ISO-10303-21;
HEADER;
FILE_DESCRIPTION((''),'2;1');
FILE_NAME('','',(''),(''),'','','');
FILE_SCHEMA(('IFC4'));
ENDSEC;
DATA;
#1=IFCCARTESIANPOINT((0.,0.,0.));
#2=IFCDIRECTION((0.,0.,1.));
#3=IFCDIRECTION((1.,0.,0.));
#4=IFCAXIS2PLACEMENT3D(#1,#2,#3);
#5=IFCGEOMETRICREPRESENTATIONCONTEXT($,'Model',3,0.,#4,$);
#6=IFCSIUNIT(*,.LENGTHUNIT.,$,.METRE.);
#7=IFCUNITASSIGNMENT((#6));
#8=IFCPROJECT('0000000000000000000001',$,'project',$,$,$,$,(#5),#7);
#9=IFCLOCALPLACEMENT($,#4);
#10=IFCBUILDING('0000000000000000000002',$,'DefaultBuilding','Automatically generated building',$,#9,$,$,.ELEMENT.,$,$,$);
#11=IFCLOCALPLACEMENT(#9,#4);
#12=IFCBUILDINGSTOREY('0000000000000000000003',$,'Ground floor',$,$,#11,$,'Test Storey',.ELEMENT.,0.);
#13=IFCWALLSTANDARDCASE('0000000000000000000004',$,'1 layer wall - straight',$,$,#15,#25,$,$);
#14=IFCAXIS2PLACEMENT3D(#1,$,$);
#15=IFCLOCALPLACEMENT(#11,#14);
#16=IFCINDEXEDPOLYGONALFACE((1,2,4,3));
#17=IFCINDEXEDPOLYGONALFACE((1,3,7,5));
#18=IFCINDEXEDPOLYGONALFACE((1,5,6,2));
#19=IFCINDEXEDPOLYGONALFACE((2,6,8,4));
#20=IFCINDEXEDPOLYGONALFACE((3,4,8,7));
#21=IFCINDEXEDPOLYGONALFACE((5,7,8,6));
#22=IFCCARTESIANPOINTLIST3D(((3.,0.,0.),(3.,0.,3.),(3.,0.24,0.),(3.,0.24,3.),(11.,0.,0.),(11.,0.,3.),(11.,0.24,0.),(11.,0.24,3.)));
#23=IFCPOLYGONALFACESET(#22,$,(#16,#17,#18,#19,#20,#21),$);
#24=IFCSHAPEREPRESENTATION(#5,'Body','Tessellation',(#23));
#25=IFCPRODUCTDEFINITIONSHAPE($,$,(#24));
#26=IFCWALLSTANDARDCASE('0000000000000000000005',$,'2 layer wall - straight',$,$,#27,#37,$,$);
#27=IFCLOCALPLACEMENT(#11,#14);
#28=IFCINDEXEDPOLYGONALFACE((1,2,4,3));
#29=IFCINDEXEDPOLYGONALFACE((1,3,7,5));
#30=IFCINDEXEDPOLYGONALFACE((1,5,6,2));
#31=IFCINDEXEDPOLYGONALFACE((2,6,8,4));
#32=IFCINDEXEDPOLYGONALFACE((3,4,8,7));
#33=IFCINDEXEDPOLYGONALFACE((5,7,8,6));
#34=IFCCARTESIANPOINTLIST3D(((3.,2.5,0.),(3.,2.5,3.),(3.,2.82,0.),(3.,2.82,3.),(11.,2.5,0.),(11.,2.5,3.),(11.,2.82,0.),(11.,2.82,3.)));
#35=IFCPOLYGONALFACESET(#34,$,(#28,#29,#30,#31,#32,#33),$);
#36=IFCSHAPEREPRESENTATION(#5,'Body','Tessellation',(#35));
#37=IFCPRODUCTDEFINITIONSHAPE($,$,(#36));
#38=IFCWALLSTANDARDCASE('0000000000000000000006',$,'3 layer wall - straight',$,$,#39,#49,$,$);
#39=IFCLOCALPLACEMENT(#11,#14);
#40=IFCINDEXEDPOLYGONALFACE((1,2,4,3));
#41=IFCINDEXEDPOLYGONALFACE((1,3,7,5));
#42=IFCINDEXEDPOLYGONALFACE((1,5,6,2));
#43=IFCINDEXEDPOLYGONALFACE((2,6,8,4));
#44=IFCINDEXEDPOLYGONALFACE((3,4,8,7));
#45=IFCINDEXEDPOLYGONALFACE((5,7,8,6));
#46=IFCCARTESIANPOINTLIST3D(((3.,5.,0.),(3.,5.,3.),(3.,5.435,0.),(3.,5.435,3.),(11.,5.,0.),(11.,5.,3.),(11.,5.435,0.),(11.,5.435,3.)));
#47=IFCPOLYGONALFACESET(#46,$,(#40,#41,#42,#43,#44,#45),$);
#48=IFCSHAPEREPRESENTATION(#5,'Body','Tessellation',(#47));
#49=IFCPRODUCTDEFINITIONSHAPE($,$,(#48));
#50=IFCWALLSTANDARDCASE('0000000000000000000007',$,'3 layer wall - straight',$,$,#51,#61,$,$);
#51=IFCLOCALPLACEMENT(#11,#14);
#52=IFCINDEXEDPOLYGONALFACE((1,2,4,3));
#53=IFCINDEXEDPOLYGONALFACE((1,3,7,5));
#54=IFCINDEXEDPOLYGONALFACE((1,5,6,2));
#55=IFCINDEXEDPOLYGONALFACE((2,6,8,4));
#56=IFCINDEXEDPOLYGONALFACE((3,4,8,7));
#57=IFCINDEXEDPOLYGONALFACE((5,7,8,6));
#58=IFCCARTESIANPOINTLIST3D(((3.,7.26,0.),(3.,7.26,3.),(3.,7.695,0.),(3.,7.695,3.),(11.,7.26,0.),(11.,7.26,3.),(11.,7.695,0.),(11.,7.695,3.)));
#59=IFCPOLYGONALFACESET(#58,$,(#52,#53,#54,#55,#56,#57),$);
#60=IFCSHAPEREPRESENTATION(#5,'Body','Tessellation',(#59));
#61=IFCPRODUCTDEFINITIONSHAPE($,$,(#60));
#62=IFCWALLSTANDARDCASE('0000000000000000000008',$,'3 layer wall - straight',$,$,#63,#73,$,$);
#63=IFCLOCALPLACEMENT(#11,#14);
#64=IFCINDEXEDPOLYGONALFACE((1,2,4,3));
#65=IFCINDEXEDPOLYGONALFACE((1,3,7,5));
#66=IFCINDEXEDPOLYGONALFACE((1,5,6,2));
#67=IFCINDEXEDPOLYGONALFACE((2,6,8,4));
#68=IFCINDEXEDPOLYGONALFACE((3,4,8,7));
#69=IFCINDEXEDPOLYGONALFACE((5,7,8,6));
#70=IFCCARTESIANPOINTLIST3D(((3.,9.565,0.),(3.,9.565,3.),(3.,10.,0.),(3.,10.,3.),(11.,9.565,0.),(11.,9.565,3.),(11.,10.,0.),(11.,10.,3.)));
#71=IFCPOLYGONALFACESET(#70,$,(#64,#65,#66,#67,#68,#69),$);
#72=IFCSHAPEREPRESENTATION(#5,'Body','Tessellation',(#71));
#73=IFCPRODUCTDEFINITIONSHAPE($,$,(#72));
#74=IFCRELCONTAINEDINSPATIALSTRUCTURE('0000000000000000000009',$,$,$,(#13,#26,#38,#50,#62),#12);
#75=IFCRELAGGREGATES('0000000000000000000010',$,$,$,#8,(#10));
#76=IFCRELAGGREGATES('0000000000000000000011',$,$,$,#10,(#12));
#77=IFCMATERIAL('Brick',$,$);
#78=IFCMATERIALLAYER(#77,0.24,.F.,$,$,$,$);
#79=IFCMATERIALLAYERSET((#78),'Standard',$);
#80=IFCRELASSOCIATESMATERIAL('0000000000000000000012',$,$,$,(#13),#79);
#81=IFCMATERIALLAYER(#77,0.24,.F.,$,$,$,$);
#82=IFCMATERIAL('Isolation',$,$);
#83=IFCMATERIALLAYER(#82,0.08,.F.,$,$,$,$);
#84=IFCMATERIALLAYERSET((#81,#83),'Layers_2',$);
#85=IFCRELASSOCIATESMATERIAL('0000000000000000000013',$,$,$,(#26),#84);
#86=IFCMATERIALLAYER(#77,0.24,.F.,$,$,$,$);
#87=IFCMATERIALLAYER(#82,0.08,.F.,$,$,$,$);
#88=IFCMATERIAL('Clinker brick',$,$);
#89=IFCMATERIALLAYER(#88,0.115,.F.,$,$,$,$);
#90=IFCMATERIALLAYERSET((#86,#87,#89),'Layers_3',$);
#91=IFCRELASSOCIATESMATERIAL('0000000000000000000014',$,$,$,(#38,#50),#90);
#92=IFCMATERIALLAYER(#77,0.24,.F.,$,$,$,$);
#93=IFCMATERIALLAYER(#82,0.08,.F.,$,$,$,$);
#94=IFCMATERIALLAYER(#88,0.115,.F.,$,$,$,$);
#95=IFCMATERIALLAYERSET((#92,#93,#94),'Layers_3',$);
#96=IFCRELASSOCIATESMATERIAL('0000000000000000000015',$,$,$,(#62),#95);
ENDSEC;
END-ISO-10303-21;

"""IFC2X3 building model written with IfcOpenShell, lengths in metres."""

from ifc_helpers import new_model, si_unit, frame, origin_with_axes, place, context, project, spatial, polyline, outline, extrude, material, layer, layer_set, layer_usage, element, save


model = new_model("IFC2X3")

# Units and contexts
model_context = context("Model", 3, precision=0.0, world=origin_with_axes())
ifc_project = project(units=[si_unit("LENGTHUNIT", "METRE")], contexts=[model_context])

# Building, storey
building_placement = place(None, origin_with_axes())
building = spatial("IfcBuilding", under=ifc_project, at=building_placement, Name="DefaultBuilding", Description="Automatically generated building", CompositionType="ELEMENT")
storey_placement = place(building_placement, origin_with_axes())
storey = spatial("IfcBuildingStorey", under=building, at=storey_placement, Name="Ground floor", LongName="Test Storey", CompositionType="ELEMENT", Elevation=0.0)

# Walls
ifc_material_1 = material(Name="Brick")
ifc_layer_1 = layer(ifc_material_1, 0.24, ventilated=False)
ifc_layer_set_1 = layer_set([ifc_layer_1], Name="Standard")
ifc_layer_usage_1 = layer_usage(ifc_layer_set_1, "AXIS2", "POSITIVE", 0.0)
wall_1_placement = place(storey_placement, frame((3.0, 0.0, 0.0), z_axis=(0.0, 0.0, 1.0), x_axis=(1.0, 0.0, 0.0)))
element("IfcWallStandardCase", 1, at=wall_1_placement, inside=storey, material=ifc_layer_usage_1, Name="1 layer wall - straight", context=model_context, shape_type="SweptSolid", body=[
    extrude(outline(polyline([(0.0, 0.24), (0.0, 0.0), (8.0, 0.0), (8.0, 0.24), (0.0, 0.24)])), origin_with_axes(), (0.0, 0.0, 1.0), 3.0),
])
ifc_layer_2 = layer(ifc_material_1, 0.24, ventilated=False)
ifc_material_2 = material(Name="Isolation")
ifc_layer_3 = layer(ifc_material_2, 0.08, ventilated=False)
ifc_layer_set_2 = layer_set([ifc_layer_2, ifc_layer_3], Name="Layers_2")
ifc_layer_usage_2 = layer_usage(ifc_layer_set_2, "AXIS2", "POSITIVE", 0.0)
wall_2_placement = place(storey_placement, frame((3.0, 2.5, 0.0), z_axis=(0.0, 0.0, 1.0), x_axis=(1.0, 0.0, 0.0)))
element("IfcWallStandardCase", 2, at=wall_2_placement, inside=storey, material=ifc_layer_usage_2, Name="2 layer wall - straight", context=model_context, shape_type="SweptSolid", body=[
    extrude(outline(polyline([(0.0, 0.0), (8.0, 0.0), (8.0, 0.32), (0.0, 0.32), (0.0, 0.0)])), origin_with_axes(), (0.0, 0.0, 1.0), 3.0),
])
ifc_layer_4 = layer(ifc_material_1, 0.24, ventilated=False)
ifc_layer_5 = layer(ifc_material_2, 0.08, ventilated=False)
ifc_material_3 = material(Name="Clinker brick")
ifc_layer_6 = layer(ifc_material_3, 0.115, ventilated=False)
ifc_layer_set_3 = layer_set([ifc_layer_4, ifc_layer_5, ifc_layer_6], Name="Layers_3")
ifc_layer_usage_3 = layer_usage(ifc_layer_set_3, "AXIS2", "POSITIVE", 0.0)
wall_3_placement = place(storey_placement, frame((3.0, 5.0, 0.0), z_axis=(0.0, 0.0, 1.0), x_axis=(1.0, 0.0, 0.0)))
element("IfcWallStandardCase", 3, at=wall_3_placement, inside=storey, material=ifc_layer_usage_3, Name="3 layer wall - straight", context=model_context, shape_type="SweptSolid", body=[
    extrude(outline(polyline([(0.0, 0.0), (8.0, 0.0), (8.0, 0.435), (0.0, 0.435), (0.0, 0.0)])), origin_with_axes(), (0.0, 0.0, 1.0), 3.0),
])
ifc_layer_usage_4 = layer_usage(ifc_layer_set_3, "AXIS2", "POSITIVE", -0.2175)
wall_4_placement = place(storey_placement, frame((3.0, 7.4775, 0.0), z_axis=(0.0, 0.0, 1.0), x_axis=(1.0, 0.0, 0.0)))
element("IfcWallStandardCase", 4, at=wall_4_placement, inside=storey, material=ifc_layer_usage_4, Name="3 layer wall - straight", context=model_context, shape_type="SweptSolid", body=[
    extrude(outline(polyline([(0.0, -0.2175), (8.0, -0.2175), (8.0, 0.2175), (0.0, 0.2175), (0.0, -0.2175)])), origin_with_axes(), (0.0, 0.0, 1.0), 3.0),
])
ifc_layer_7 = layer(ifc_material_1, 0.24, ventilated=False)
ifc_layer_8 = layer(ifc_material_2, 0.08, ventilated=False)
ifc_layer_9 = layer(ifc_material_3, 0.115, ventilated=False)
ifc_layer_set_4 = layer_set([ifc_layer_7, ifc_layer_8, ifc_layer_9], Name="Layers_3")
ifc_layer_usage_5 = layer_usage(ifc_layer_set_4, "AXIS2", "POSITIVE", -0.435)
wall_5_placement = place(storey_placement, frame((3.0, 10.0, 0.0), z_axis=(0.0, 0.0, 1.0), x_axis=(1.0, 0.0, 0.0)))
element("IfcWallStandardCase", 5, at=wall_5_placement, inside=storey, material=ifc_layer_usage_5, Name="3 layer wall - straight", context=model_context, shape_type="SweptSolid", body=[
    extrude(outline(polyline([(0.0, -0.435), (8.0, -0.435), (8.0, 0.0), (0.0, 0.0), (0.0, -0.435)])), origin_with_axes(), (0.0, 0.0, 1.0), 3.0),
])

save(model, "model.ifc")
